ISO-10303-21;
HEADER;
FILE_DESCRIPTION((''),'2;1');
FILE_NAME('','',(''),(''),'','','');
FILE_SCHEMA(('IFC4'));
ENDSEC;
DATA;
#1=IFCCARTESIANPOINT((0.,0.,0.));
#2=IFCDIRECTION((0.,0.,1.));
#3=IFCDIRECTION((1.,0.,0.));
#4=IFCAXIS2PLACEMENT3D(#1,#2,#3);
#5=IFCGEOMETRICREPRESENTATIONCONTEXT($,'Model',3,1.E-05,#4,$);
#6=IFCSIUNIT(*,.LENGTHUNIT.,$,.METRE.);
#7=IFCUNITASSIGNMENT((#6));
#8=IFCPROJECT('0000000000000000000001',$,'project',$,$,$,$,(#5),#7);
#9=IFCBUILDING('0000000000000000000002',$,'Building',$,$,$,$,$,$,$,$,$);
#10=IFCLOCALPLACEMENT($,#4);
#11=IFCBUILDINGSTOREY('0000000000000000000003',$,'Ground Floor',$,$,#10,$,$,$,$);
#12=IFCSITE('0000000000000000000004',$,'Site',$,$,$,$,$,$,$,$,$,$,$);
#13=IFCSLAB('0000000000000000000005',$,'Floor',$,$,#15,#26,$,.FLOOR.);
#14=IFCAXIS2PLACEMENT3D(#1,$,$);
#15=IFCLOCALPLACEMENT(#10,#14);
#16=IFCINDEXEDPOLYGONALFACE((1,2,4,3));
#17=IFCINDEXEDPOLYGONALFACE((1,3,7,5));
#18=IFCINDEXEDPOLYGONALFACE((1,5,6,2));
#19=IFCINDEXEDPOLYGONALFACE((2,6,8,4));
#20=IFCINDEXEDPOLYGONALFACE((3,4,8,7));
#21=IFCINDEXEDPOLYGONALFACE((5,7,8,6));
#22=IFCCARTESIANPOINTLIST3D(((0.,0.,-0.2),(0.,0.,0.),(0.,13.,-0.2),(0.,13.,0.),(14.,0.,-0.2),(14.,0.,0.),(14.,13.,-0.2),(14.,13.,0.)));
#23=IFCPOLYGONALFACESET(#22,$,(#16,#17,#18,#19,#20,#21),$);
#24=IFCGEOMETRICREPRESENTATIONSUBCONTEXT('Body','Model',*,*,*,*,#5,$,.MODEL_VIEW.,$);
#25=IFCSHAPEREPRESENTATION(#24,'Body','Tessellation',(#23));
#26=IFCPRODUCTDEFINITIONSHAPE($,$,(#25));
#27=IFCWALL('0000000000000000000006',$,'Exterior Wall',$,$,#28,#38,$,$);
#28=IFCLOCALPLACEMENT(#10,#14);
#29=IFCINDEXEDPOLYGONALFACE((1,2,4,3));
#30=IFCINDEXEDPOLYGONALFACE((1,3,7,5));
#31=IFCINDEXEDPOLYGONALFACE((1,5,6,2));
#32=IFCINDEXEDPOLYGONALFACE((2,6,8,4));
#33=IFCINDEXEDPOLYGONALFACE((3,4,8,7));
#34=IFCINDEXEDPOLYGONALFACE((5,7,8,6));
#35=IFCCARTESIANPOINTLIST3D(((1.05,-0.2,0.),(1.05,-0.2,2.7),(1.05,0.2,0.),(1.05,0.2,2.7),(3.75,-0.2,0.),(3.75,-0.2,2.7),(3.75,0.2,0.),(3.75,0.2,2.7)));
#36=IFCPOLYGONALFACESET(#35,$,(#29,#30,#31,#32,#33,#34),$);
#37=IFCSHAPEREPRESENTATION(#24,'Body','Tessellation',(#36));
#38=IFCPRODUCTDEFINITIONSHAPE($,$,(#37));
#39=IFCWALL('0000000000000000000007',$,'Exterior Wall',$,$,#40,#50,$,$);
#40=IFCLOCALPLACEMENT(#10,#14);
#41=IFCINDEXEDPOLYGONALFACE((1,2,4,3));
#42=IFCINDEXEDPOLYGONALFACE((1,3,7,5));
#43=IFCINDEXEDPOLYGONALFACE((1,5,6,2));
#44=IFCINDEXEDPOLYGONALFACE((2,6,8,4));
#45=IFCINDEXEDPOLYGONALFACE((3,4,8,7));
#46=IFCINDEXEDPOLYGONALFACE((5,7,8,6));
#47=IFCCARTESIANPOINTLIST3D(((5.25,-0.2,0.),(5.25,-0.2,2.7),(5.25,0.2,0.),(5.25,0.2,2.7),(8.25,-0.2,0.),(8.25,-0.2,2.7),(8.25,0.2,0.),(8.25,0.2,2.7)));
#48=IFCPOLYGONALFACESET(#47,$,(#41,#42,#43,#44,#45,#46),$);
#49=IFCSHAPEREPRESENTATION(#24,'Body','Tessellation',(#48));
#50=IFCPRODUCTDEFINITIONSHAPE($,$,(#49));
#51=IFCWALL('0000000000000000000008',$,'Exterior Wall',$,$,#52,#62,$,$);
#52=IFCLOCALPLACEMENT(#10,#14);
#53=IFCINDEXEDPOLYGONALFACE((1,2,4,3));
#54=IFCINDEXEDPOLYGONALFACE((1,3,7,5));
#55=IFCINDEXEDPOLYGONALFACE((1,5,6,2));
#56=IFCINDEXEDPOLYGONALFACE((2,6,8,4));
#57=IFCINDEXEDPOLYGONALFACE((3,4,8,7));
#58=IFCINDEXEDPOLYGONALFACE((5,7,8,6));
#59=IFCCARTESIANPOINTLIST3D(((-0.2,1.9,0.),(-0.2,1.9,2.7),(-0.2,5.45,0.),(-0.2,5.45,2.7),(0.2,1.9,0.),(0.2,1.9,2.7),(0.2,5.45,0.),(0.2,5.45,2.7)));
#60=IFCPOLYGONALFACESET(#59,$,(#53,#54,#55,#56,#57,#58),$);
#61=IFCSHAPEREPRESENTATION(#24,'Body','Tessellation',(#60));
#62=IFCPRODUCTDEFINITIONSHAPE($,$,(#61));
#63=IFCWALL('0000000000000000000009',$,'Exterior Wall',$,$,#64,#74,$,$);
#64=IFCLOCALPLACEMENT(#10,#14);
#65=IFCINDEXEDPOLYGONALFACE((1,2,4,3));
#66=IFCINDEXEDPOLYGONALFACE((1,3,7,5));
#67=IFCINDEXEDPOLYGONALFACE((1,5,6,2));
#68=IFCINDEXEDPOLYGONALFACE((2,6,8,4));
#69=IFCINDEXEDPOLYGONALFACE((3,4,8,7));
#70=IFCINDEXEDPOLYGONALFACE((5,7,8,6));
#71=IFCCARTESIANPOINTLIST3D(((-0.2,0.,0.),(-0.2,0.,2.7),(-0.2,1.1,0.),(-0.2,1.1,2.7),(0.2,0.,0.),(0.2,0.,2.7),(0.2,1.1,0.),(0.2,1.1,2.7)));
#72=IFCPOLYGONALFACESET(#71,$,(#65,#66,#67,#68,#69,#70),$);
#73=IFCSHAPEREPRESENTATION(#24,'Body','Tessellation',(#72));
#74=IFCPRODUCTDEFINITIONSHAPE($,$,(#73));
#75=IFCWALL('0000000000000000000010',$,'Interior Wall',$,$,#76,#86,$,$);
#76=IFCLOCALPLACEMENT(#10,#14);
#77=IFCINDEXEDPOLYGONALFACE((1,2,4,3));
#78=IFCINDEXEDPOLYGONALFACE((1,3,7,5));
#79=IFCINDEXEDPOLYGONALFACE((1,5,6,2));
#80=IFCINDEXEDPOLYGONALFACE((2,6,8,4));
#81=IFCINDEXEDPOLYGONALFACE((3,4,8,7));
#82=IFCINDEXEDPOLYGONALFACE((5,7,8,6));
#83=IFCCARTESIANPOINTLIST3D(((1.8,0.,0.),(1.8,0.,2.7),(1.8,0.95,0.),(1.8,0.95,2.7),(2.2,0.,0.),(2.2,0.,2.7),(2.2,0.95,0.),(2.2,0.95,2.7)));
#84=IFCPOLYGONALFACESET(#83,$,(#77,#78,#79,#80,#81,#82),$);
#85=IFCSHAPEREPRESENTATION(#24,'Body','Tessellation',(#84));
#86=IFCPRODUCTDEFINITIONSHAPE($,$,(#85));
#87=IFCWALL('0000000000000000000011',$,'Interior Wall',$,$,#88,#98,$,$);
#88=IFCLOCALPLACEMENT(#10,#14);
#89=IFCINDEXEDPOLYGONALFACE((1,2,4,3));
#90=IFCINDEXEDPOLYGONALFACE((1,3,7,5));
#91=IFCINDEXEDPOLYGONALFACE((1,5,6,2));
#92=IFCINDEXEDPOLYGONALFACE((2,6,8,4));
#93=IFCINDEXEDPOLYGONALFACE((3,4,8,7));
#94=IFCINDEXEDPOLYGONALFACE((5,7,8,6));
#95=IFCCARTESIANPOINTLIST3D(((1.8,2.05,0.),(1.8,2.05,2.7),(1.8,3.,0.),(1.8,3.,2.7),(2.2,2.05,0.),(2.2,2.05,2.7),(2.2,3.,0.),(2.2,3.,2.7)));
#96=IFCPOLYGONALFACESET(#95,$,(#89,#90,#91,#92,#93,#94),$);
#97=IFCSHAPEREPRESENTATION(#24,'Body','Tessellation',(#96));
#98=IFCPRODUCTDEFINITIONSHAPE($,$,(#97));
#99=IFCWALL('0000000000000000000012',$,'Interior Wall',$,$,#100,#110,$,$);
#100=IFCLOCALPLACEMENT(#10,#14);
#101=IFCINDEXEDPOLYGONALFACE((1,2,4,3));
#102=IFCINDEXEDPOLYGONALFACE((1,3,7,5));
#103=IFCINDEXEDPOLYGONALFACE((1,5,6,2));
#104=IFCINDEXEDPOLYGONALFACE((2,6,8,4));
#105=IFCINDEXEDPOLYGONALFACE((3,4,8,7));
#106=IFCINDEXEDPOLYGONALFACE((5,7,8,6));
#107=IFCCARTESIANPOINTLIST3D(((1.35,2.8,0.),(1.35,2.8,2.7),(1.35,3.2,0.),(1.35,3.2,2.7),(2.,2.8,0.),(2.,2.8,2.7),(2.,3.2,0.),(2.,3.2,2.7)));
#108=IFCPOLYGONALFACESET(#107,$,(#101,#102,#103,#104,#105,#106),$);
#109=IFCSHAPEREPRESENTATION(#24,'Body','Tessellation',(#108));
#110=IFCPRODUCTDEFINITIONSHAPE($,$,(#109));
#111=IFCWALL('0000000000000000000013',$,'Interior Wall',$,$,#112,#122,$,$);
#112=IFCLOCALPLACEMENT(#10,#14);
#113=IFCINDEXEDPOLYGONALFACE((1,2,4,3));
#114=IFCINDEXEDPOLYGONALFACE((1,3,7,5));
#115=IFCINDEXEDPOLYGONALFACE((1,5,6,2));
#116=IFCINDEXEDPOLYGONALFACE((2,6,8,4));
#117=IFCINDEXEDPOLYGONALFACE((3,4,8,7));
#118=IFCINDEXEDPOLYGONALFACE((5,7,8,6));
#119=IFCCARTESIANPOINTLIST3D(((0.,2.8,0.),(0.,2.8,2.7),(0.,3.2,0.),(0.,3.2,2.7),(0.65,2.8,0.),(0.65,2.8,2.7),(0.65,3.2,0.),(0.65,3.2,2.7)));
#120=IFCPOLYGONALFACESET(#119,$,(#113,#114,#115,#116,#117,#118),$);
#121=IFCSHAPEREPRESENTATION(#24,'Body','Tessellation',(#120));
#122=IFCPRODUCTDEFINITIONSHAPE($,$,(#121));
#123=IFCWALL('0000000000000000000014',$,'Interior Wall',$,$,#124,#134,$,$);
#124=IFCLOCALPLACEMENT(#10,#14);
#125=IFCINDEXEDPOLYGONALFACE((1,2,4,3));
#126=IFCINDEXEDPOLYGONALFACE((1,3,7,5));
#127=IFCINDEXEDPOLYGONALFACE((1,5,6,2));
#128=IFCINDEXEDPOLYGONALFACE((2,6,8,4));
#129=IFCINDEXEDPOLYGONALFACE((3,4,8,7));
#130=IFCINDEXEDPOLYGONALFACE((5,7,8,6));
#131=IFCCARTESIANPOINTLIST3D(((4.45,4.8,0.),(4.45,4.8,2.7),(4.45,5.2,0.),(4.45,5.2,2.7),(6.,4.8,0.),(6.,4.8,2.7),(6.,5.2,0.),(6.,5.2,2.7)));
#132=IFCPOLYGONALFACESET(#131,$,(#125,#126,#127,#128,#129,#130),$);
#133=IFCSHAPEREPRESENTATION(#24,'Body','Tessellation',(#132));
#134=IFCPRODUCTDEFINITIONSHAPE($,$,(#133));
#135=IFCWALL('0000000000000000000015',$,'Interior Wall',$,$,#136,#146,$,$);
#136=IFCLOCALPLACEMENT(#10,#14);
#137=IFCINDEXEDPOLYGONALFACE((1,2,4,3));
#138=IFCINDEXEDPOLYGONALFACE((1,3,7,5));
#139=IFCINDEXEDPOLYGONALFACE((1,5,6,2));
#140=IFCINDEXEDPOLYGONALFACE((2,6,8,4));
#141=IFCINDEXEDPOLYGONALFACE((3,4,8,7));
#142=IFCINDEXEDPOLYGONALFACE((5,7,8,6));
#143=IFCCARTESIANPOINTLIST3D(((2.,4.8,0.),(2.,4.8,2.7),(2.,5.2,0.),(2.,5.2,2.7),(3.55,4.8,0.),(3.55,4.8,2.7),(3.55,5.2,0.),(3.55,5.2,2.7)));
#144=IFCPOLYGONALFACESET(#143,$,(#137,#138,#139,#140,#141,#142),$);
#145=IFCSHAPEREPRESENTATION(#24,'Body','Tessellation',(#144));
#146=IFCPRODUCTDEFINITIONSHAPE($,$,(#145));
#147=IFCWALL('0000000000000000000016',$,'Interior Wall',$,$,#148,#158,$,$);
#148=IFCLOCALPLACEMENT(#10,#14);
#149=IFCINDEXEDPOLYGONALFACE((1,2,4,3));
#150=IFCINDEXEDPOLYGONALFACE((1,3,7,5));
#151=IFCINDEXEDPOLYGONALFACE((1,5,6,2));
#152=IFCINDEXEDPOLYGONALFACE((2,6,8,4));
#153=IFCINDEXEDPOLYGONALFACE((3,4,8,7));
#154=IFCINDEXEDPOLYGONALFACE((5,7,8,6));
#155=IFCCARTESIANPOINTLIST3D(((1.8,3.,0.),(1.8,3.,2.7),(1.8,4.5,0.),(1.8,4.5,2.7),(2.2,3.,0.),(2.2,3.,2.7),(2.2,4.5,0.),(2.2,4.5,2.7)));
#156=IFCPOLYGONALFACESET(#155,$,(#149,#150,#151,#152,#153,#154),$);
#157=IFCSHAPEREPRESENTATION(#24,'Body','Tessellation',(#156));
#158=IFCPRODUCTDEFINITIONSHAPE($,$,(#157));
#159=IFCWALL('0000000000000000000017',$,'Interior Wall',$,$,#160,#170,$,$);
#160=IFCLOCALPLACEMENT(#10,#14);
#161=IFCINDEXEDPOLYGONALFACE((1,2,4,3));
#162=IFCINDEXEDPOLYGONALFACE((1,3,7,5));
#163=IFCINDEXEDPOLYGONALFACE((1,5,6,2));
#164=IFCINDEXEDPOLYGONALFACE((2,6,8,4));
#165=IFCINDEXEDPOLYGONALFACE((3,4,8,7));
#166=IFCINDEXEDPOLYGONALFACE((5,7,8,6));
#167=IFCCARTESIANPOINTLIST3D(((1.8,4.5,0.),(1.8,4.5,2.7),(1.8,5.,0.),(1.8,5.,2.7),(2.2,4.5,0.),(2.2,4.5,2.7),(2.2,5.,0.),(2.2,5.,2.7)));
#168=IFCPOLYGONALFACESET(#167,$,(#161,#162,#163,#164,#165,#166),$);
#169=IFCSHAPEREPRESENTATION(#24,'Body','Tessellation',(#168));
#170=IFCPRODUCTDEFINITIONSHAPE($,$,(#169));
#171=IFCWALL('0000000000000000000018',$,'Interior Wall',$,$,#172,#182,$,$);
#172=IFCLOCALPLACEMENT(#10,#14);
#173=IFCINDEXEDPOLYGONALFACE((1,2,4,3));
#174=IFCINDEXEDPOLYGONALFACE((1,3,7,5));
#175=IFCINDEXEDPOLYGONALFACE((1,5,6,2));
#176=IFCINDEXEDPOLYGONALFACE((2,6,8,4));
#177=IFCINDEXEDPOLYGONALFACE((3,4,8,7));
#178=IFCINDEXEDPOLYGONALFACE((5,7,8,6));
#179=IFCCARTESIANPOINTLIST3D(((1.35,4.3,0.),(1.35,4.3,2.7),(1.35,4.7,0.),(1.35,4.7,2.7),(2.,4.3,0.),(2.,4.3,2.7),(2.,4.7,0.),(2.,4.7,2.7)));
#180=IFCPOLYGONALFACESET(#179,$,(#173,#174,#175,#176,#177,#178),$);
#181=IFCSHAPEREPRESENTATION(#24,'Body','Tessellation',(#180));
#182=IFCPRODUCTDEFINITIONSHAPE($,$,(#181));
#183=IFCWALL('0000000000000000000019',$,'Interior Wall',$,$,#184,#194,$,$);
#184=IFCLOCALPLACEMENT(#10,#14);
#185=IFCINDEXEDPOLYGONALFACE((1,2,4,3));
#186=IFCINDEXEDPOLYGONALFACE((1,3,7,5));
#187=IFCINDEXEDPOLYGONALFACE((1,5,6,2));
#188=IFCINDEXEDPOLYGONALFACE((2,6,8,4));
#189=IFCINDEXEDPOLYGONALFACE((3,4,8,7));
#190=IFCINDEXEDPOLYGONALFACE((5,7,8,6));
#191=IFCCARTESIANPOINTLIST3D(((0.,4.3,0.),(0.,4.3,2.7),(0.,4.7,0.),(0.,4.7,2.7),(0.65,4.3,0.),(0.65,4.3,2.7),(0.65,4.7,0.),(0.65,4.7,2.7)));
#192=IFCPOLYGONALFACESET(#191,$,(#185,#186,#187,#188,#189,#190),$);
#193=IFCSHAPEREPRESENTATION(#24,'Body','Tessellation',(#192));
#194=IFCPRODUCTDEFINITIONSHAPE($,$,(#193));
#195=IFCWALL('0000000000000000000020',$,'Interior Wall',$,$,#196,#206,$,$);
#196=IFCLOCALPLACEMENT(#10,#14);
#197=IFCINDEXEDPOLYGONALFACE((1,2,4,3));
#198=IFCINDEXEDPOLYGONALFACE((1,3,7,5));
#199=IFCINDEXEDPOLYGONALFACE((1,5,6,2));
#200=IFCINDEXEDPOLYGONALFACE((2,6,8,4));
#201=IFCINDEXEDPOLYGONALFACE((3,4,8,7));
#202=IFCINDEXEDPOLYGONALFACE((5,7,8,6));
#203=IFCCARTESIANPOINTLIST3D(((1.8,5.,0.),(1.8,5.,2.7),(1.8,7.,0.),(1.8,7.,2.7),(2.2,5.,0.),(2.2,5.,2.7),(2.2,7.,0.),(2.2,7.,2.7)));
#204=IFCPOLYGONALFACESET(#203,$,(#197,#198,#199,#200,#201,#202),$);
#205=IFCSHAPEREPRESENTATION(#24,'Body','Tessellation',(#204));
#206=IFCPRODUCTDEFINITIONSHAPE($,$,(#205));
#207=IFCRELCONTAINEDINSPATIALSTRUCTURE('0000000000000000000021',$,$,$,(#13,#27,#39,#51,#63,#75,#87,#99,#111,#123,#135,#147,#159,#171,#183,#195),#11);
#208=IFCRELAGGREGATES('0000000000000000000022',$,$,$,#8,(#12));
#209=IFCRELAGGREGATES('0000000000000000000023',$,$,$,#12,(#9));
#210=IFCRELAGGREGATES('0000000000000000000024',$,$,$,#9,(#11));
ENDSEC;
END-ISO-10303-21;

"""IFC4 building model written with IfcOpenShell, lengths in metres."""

from ifc_helpers import new_model, si_unit, frame, origin_with_axes, place, context, subcontext, project, spatial, indexed_curve, outline, extrude, element, save


model = new_model("IFC4")

# Units and contexts
model_context = context("Model", 3, precision=1e-05, world=origin_with_axes())
body_context = subcontext(model_context, "Body", "Model", "MODEL_VIEW")
ifc_project = project(units=[si_unit("LENGTHUNIT", "METRE")], contexts=[model_context])

# Site, building, storey
site = spatial("IfcSite", under=ifc_project, Name="Site")
building = spatial("IfcBuilding", under=site, Name="Building")
storey_placement = place(None, origin_with_axes())
storey = spatial("IfcBuildingStorey", under=building, at=storey_placement, Name="Ground Floor")

# Slab
slab_placement = place(storey_placement, frame((0.0, 0.0, -0.2), z_axis=(0.0, 0.0, 1.0), x_axis=(1.0, 0.0, 0.0)))
element("IfcSlab", 1, at=slab_placement, inside=storey, Name="Floor", PredefinedType="FLOOR", context=body_context, shape_type="SweptSolid", body=[
    extrude(outline(indexed_curve([(0.0, 0.0), (14.0, 0.0), (14.0, 13.0), (0.0, 13.0)])), None, (0.0, 0.0, 1.0), 0.2),
])

# Walls
wall_1_placement = place(storey_placement, frame((1.05, 0.0, 0.0), z_axis=(0.0, 0.0, 1.0), x_axis=(1.0, 0.0, 0.0)))
element("IfcWall", 2, at=wall_1_placement, inside=storey, Name="Exterior Wall", context=body_context, shape_type="SweptSolid", body=[
    extrude(outline(indexed_curve([(0.0, 0.0), (0.0, 0.4), (2.7, 0.4), (2.7, 0.0), (0.0, 0.0)], self_intersect=False)), frame((0.0, -0.2, 0.0), z_axis=(0.0, 0.0, 1.0), x_axis=(1.0, 0.0, 0.0)), (0.0, 0.0, 1.0), 2.7),
])
wall_2_placement = place(storey_placement, frame((5.25, 0.0, 0.0), z_axis=(0.0, 0.0, 1.0), x_axis=(1.0, 0.0, 0.0)))
element("IfcWall", 3, at=wall_2_placement, inside=storey, Name="Exterior Wall", context=body_context, shape_type="SweptSolid", body=[
    extrude(outline(indexed_curve([(0.0, 0.0), (0.0, 0.4), (3.0, 0.4), (3.0, 0.0), (0.0, 0.0)], self_intersect=False)), frame((0.0, -0.2, 0.0), z_axis=(0.0, 0.0, 1.0), x_axis=(1.0, 0.0, 0.0)), (0.0, 0.0, 1.0), 2.7),
])
wall_3_placement = place(storey_placement, frame((0.0, 5.45, 0.0), z_axis=(0.0, 0.0, 1.0), x_axis=(0.0, -1.0, 0.0)))
element("IfcWall", 4, at=wall_3_placement, inside=storey, Name="Exterior Wall", context=body_context, shape_type="SweptSolid", body=[
    extrude(outline(indexed_curve([(0.0, 0.0), (0.0, 0.4), (3.55, 0.4), (3.55, 0.0), (0.0, 0.0)], self_intersect=False)), frame((0.0, -0.2, 0.0), z_axis=(0.0, 0.0, 1.0), x_axis=(1.0, 0.0, 0.0)), (0.0, 0.0, 1.0), 2.7),
])
wall_4_placement = place(storey_placement, frame((0.0, 1.1, 0.0), z_axis=(0.0, 0.0, 1.0), x_axis=(0.0, -1.0, 0.0)))
element("IfcWall", 5, at=wall_4_placement, inside=storey, Name="Exterior Wall", context=body_context, shape_type="SweptSolid", body=[
    extrude(outline(indexed_curve([(0.0, 0.0), (0.0, 0.4), (1.1, 0.4), (1.1, 0.0), (0.0, 0.0)], self_intersect=False)), frame((0.0, -0.2, 0.0), z_axis=(0.0, 0.0, 1.0), x_axis=(1.0, 0.0, 0.0)), (0.0, 0.0, 1.0), 2.7),
])
wall_5_placement = place(storey_placement, frame((2.0, 0.0, 0.0), z_axis=(0.0, 0.0, 1.0), x_axis=(0.0, 1.0, 0.0)))
element("IfcWall", 6, at=wall_5_placement, inside=storey, Name="Interior Wall", context=body_context, shape_type="SweptSolid", body=[
    extrude(outline(indexed_curve([(0.0, 0.0), (0.0, 0.4), (0.95, 0.4), (0.95, 0.0), (0.0, 0.0)], self_intersect=False)), frame((0.0, -0.2, 0.0), z_axis=(0.0, 0.0, 1.0), x_axis=(1.0, 0.0, 0.0)), (0.0, 0.0, 1.0), 2.7),
])
wall_6_placement = place(storey_placement, frame((2.0, 2.05, 0.0), z_axis=(0.0, 0.0, 1.0), x_axis=(0.0, 1.0, 0.0)))
element("IfcWall", 7, at=wall_6_placement, inside=storey, Name="Interior Wall", context=body_context, shape_type="SweptSolid", body=[
    extrude(outline(indexed_curve([(0.0, 0.0), (0.0, 0.4), (0.95, 0.4), (0.95, 0.0), (0.0, 0.0)], self_intersect=False)), frame((0.0, -0.2, 0.0), z_axis=(0.0, 0.0, 1.0), x_axis=(1.0, 0.0, 0.0)), (0.0, 0.0, 1.0), 2.7),
])
for number, where, z_axis, x_axis, name in (
    (8, (2.0, 3.0, 0.0), (0.0, 0.0, 1.0), (-1.0, 0.0, 0.0), "Interior Wall"),
    (9, (0.65, 3.0, 0.0), (0.0, 0.0, 1.0), (-1.0, 0.0, 0.0), "Interior Wall"),
):
    element("IfcWall", number, at=place(storey_placement, frame(where, z_axis=z_axis, x_axis=x_axis)), inside=storey, Name=name, context=body_context, shape_type="SweptSolid", body=[
        extrude(outline(indexed_curve([(0.0, 0.0), (0.0, 0.4), (0.65, 0.4), (0.65, 0.0), (0.0, 0.0)], self_intersect=False)), frame((0.0, -0.2, 0.0), z_axis=(0.0, 0.0, 1.0), x_axis=(1.0, 0.0, 0.0)), (0.0, 0.0, 1.0), 2.7),
    ])
for number, where, z_axis, x_axis, name in (
    (10, (6.0, 5.0, 0.0), (0.0, 0.0, 1.0), (-1.0, 0.0, 0.0), "Interior Wall"),
    (11, (3.55, 5.0, 0.0), (0.0, 0.0, 1.0), (-1.0, 0.0, 0.0), "Interior Wall"),
):
    element("IfcWall", number, at=place(storey_placement, frame(where, z_axis=z_axis, x_axis=x_axis)), inside=storey, Name=name, context=body_context, shape_type="SweptSolid", body=[
        extrude(outline(indexed_curve([(0.0, 0.0), (0.0, 0.4), (1.55, 0.4), (1.55, 0.0), (0.0, 0.0)], self_intersect=False)), frame((0.0, -0.2, 0.0), z_axis=(0.0, 0.0, 1.0), x_axis=(1.0, 0.0, 0.0)), (0.0, 0.0, 1.0), 2.7),
    ])
wall_7_placement = place(storey_placement, frame((2.0, 4.5, 0.0), z_axis=(0.0, 0.0, 1.0), x_axis=(0.0, -1.0, 0.0)))
element("IfcWall", 12, at=wall_7_placement, inside=storey, Name="Interior Wall", context=body_context, shape_type="SweptSolid", body=[
    extrude(outline(indexed_curve([(0.0, 0.0), (0.0, 0.4), (1.5, 0.4), (1.5, 0.0), (0.0, 0.0)], self_intersect=False)), frame((0.0, -0.2, 0.0), z_axis=(0.0, 0.0, 1.0), x_axis=(1.0, 0.0, 0.0)), (0.0, 0.0, 1.0), 2.7),
])
wall_8_placement = place(storey_placement, frame((2.0, 5.0, 0.0), z_axis=(0.0, 0.0, 1.0), x_axis=(0.0, -1.0, 0.0)))
element("IfcWall", 13, at=wall_8_placement, inside=storey, Name="Interior Wall", context=body_context, shape_type="SweptSolid", body=[
    extrude(outline(indexed_curve([(0.0, 0.0), (0.0, 0.4), (0.5, 0.4), (0.5, 0.0), (0.0, 0.0)], self_intersect=False)), frame((0.0, -0.2, 0.0), z_axis=(0.0, 0.0, 1.0), x_axis=(1.0, 0.0, 0.0)), (0.0, 0.0, 1.0), 2.7),
])
for number, where, z_axis, x_axis, name in (
    (14, (2.0, 4.5, 0.0), (0.0, 0.0, 1.0), (-1.0, 0.0, 0.0), "Interior Wall"),
    (15, (0.65, 4.5, 0.0), (0.0, 0.0, 1.0), (-1.0, 0.0, 0.0), "Interior Wall"),
):
    element("IfcWall", number, at=place(storey_placement, frame(where, z_axis=z_axis, x_axis=x_axis)), inside=storey, Name=name, context=body_context, shape_type="SweptSolid", body=[
        extrude(outline(indexed_curve([(0.0, 0.0), (0.0, 0.4), (0.65, 0.4), (0.65, 0.0), (0.0, 0.0)], self_intersect=False)), frame((0.0, -0.2, 0.0), z_axis=(0.0, 0.0, 1.0), x_axis=(1.0, 0.0, 0.0)), (0.0, 0.0, 1.0), 2.7),
    ])
wall_9_placement = place(storey_placement, frame((2.0, 5.0, 0.0), z_axis=(0.0, 0.0, 1.0), x_axis=(0.0, 1.0, 0.0)))
element("IfcWall", 16, at=wall_9_placement, inside=storey, Name="Interior Wall", context=body_context, shape_type="SweptSolid", body=[
    extrude(outline(indexed_curve([(0.0, 0.0), (0.0, 0.4), (2.0, 0.4), (2.0, 0.0), (0.0, 0.0)], self_intersect=False)), frame((0.0, -0.2, 0.0), z_axis=(0.0, 0.0, 1.0), x_axis=(1.0, 0.0, 0.0)), (0.0, 0.0, 1.0), 2.7),
])

save(model, "model.ifc")
